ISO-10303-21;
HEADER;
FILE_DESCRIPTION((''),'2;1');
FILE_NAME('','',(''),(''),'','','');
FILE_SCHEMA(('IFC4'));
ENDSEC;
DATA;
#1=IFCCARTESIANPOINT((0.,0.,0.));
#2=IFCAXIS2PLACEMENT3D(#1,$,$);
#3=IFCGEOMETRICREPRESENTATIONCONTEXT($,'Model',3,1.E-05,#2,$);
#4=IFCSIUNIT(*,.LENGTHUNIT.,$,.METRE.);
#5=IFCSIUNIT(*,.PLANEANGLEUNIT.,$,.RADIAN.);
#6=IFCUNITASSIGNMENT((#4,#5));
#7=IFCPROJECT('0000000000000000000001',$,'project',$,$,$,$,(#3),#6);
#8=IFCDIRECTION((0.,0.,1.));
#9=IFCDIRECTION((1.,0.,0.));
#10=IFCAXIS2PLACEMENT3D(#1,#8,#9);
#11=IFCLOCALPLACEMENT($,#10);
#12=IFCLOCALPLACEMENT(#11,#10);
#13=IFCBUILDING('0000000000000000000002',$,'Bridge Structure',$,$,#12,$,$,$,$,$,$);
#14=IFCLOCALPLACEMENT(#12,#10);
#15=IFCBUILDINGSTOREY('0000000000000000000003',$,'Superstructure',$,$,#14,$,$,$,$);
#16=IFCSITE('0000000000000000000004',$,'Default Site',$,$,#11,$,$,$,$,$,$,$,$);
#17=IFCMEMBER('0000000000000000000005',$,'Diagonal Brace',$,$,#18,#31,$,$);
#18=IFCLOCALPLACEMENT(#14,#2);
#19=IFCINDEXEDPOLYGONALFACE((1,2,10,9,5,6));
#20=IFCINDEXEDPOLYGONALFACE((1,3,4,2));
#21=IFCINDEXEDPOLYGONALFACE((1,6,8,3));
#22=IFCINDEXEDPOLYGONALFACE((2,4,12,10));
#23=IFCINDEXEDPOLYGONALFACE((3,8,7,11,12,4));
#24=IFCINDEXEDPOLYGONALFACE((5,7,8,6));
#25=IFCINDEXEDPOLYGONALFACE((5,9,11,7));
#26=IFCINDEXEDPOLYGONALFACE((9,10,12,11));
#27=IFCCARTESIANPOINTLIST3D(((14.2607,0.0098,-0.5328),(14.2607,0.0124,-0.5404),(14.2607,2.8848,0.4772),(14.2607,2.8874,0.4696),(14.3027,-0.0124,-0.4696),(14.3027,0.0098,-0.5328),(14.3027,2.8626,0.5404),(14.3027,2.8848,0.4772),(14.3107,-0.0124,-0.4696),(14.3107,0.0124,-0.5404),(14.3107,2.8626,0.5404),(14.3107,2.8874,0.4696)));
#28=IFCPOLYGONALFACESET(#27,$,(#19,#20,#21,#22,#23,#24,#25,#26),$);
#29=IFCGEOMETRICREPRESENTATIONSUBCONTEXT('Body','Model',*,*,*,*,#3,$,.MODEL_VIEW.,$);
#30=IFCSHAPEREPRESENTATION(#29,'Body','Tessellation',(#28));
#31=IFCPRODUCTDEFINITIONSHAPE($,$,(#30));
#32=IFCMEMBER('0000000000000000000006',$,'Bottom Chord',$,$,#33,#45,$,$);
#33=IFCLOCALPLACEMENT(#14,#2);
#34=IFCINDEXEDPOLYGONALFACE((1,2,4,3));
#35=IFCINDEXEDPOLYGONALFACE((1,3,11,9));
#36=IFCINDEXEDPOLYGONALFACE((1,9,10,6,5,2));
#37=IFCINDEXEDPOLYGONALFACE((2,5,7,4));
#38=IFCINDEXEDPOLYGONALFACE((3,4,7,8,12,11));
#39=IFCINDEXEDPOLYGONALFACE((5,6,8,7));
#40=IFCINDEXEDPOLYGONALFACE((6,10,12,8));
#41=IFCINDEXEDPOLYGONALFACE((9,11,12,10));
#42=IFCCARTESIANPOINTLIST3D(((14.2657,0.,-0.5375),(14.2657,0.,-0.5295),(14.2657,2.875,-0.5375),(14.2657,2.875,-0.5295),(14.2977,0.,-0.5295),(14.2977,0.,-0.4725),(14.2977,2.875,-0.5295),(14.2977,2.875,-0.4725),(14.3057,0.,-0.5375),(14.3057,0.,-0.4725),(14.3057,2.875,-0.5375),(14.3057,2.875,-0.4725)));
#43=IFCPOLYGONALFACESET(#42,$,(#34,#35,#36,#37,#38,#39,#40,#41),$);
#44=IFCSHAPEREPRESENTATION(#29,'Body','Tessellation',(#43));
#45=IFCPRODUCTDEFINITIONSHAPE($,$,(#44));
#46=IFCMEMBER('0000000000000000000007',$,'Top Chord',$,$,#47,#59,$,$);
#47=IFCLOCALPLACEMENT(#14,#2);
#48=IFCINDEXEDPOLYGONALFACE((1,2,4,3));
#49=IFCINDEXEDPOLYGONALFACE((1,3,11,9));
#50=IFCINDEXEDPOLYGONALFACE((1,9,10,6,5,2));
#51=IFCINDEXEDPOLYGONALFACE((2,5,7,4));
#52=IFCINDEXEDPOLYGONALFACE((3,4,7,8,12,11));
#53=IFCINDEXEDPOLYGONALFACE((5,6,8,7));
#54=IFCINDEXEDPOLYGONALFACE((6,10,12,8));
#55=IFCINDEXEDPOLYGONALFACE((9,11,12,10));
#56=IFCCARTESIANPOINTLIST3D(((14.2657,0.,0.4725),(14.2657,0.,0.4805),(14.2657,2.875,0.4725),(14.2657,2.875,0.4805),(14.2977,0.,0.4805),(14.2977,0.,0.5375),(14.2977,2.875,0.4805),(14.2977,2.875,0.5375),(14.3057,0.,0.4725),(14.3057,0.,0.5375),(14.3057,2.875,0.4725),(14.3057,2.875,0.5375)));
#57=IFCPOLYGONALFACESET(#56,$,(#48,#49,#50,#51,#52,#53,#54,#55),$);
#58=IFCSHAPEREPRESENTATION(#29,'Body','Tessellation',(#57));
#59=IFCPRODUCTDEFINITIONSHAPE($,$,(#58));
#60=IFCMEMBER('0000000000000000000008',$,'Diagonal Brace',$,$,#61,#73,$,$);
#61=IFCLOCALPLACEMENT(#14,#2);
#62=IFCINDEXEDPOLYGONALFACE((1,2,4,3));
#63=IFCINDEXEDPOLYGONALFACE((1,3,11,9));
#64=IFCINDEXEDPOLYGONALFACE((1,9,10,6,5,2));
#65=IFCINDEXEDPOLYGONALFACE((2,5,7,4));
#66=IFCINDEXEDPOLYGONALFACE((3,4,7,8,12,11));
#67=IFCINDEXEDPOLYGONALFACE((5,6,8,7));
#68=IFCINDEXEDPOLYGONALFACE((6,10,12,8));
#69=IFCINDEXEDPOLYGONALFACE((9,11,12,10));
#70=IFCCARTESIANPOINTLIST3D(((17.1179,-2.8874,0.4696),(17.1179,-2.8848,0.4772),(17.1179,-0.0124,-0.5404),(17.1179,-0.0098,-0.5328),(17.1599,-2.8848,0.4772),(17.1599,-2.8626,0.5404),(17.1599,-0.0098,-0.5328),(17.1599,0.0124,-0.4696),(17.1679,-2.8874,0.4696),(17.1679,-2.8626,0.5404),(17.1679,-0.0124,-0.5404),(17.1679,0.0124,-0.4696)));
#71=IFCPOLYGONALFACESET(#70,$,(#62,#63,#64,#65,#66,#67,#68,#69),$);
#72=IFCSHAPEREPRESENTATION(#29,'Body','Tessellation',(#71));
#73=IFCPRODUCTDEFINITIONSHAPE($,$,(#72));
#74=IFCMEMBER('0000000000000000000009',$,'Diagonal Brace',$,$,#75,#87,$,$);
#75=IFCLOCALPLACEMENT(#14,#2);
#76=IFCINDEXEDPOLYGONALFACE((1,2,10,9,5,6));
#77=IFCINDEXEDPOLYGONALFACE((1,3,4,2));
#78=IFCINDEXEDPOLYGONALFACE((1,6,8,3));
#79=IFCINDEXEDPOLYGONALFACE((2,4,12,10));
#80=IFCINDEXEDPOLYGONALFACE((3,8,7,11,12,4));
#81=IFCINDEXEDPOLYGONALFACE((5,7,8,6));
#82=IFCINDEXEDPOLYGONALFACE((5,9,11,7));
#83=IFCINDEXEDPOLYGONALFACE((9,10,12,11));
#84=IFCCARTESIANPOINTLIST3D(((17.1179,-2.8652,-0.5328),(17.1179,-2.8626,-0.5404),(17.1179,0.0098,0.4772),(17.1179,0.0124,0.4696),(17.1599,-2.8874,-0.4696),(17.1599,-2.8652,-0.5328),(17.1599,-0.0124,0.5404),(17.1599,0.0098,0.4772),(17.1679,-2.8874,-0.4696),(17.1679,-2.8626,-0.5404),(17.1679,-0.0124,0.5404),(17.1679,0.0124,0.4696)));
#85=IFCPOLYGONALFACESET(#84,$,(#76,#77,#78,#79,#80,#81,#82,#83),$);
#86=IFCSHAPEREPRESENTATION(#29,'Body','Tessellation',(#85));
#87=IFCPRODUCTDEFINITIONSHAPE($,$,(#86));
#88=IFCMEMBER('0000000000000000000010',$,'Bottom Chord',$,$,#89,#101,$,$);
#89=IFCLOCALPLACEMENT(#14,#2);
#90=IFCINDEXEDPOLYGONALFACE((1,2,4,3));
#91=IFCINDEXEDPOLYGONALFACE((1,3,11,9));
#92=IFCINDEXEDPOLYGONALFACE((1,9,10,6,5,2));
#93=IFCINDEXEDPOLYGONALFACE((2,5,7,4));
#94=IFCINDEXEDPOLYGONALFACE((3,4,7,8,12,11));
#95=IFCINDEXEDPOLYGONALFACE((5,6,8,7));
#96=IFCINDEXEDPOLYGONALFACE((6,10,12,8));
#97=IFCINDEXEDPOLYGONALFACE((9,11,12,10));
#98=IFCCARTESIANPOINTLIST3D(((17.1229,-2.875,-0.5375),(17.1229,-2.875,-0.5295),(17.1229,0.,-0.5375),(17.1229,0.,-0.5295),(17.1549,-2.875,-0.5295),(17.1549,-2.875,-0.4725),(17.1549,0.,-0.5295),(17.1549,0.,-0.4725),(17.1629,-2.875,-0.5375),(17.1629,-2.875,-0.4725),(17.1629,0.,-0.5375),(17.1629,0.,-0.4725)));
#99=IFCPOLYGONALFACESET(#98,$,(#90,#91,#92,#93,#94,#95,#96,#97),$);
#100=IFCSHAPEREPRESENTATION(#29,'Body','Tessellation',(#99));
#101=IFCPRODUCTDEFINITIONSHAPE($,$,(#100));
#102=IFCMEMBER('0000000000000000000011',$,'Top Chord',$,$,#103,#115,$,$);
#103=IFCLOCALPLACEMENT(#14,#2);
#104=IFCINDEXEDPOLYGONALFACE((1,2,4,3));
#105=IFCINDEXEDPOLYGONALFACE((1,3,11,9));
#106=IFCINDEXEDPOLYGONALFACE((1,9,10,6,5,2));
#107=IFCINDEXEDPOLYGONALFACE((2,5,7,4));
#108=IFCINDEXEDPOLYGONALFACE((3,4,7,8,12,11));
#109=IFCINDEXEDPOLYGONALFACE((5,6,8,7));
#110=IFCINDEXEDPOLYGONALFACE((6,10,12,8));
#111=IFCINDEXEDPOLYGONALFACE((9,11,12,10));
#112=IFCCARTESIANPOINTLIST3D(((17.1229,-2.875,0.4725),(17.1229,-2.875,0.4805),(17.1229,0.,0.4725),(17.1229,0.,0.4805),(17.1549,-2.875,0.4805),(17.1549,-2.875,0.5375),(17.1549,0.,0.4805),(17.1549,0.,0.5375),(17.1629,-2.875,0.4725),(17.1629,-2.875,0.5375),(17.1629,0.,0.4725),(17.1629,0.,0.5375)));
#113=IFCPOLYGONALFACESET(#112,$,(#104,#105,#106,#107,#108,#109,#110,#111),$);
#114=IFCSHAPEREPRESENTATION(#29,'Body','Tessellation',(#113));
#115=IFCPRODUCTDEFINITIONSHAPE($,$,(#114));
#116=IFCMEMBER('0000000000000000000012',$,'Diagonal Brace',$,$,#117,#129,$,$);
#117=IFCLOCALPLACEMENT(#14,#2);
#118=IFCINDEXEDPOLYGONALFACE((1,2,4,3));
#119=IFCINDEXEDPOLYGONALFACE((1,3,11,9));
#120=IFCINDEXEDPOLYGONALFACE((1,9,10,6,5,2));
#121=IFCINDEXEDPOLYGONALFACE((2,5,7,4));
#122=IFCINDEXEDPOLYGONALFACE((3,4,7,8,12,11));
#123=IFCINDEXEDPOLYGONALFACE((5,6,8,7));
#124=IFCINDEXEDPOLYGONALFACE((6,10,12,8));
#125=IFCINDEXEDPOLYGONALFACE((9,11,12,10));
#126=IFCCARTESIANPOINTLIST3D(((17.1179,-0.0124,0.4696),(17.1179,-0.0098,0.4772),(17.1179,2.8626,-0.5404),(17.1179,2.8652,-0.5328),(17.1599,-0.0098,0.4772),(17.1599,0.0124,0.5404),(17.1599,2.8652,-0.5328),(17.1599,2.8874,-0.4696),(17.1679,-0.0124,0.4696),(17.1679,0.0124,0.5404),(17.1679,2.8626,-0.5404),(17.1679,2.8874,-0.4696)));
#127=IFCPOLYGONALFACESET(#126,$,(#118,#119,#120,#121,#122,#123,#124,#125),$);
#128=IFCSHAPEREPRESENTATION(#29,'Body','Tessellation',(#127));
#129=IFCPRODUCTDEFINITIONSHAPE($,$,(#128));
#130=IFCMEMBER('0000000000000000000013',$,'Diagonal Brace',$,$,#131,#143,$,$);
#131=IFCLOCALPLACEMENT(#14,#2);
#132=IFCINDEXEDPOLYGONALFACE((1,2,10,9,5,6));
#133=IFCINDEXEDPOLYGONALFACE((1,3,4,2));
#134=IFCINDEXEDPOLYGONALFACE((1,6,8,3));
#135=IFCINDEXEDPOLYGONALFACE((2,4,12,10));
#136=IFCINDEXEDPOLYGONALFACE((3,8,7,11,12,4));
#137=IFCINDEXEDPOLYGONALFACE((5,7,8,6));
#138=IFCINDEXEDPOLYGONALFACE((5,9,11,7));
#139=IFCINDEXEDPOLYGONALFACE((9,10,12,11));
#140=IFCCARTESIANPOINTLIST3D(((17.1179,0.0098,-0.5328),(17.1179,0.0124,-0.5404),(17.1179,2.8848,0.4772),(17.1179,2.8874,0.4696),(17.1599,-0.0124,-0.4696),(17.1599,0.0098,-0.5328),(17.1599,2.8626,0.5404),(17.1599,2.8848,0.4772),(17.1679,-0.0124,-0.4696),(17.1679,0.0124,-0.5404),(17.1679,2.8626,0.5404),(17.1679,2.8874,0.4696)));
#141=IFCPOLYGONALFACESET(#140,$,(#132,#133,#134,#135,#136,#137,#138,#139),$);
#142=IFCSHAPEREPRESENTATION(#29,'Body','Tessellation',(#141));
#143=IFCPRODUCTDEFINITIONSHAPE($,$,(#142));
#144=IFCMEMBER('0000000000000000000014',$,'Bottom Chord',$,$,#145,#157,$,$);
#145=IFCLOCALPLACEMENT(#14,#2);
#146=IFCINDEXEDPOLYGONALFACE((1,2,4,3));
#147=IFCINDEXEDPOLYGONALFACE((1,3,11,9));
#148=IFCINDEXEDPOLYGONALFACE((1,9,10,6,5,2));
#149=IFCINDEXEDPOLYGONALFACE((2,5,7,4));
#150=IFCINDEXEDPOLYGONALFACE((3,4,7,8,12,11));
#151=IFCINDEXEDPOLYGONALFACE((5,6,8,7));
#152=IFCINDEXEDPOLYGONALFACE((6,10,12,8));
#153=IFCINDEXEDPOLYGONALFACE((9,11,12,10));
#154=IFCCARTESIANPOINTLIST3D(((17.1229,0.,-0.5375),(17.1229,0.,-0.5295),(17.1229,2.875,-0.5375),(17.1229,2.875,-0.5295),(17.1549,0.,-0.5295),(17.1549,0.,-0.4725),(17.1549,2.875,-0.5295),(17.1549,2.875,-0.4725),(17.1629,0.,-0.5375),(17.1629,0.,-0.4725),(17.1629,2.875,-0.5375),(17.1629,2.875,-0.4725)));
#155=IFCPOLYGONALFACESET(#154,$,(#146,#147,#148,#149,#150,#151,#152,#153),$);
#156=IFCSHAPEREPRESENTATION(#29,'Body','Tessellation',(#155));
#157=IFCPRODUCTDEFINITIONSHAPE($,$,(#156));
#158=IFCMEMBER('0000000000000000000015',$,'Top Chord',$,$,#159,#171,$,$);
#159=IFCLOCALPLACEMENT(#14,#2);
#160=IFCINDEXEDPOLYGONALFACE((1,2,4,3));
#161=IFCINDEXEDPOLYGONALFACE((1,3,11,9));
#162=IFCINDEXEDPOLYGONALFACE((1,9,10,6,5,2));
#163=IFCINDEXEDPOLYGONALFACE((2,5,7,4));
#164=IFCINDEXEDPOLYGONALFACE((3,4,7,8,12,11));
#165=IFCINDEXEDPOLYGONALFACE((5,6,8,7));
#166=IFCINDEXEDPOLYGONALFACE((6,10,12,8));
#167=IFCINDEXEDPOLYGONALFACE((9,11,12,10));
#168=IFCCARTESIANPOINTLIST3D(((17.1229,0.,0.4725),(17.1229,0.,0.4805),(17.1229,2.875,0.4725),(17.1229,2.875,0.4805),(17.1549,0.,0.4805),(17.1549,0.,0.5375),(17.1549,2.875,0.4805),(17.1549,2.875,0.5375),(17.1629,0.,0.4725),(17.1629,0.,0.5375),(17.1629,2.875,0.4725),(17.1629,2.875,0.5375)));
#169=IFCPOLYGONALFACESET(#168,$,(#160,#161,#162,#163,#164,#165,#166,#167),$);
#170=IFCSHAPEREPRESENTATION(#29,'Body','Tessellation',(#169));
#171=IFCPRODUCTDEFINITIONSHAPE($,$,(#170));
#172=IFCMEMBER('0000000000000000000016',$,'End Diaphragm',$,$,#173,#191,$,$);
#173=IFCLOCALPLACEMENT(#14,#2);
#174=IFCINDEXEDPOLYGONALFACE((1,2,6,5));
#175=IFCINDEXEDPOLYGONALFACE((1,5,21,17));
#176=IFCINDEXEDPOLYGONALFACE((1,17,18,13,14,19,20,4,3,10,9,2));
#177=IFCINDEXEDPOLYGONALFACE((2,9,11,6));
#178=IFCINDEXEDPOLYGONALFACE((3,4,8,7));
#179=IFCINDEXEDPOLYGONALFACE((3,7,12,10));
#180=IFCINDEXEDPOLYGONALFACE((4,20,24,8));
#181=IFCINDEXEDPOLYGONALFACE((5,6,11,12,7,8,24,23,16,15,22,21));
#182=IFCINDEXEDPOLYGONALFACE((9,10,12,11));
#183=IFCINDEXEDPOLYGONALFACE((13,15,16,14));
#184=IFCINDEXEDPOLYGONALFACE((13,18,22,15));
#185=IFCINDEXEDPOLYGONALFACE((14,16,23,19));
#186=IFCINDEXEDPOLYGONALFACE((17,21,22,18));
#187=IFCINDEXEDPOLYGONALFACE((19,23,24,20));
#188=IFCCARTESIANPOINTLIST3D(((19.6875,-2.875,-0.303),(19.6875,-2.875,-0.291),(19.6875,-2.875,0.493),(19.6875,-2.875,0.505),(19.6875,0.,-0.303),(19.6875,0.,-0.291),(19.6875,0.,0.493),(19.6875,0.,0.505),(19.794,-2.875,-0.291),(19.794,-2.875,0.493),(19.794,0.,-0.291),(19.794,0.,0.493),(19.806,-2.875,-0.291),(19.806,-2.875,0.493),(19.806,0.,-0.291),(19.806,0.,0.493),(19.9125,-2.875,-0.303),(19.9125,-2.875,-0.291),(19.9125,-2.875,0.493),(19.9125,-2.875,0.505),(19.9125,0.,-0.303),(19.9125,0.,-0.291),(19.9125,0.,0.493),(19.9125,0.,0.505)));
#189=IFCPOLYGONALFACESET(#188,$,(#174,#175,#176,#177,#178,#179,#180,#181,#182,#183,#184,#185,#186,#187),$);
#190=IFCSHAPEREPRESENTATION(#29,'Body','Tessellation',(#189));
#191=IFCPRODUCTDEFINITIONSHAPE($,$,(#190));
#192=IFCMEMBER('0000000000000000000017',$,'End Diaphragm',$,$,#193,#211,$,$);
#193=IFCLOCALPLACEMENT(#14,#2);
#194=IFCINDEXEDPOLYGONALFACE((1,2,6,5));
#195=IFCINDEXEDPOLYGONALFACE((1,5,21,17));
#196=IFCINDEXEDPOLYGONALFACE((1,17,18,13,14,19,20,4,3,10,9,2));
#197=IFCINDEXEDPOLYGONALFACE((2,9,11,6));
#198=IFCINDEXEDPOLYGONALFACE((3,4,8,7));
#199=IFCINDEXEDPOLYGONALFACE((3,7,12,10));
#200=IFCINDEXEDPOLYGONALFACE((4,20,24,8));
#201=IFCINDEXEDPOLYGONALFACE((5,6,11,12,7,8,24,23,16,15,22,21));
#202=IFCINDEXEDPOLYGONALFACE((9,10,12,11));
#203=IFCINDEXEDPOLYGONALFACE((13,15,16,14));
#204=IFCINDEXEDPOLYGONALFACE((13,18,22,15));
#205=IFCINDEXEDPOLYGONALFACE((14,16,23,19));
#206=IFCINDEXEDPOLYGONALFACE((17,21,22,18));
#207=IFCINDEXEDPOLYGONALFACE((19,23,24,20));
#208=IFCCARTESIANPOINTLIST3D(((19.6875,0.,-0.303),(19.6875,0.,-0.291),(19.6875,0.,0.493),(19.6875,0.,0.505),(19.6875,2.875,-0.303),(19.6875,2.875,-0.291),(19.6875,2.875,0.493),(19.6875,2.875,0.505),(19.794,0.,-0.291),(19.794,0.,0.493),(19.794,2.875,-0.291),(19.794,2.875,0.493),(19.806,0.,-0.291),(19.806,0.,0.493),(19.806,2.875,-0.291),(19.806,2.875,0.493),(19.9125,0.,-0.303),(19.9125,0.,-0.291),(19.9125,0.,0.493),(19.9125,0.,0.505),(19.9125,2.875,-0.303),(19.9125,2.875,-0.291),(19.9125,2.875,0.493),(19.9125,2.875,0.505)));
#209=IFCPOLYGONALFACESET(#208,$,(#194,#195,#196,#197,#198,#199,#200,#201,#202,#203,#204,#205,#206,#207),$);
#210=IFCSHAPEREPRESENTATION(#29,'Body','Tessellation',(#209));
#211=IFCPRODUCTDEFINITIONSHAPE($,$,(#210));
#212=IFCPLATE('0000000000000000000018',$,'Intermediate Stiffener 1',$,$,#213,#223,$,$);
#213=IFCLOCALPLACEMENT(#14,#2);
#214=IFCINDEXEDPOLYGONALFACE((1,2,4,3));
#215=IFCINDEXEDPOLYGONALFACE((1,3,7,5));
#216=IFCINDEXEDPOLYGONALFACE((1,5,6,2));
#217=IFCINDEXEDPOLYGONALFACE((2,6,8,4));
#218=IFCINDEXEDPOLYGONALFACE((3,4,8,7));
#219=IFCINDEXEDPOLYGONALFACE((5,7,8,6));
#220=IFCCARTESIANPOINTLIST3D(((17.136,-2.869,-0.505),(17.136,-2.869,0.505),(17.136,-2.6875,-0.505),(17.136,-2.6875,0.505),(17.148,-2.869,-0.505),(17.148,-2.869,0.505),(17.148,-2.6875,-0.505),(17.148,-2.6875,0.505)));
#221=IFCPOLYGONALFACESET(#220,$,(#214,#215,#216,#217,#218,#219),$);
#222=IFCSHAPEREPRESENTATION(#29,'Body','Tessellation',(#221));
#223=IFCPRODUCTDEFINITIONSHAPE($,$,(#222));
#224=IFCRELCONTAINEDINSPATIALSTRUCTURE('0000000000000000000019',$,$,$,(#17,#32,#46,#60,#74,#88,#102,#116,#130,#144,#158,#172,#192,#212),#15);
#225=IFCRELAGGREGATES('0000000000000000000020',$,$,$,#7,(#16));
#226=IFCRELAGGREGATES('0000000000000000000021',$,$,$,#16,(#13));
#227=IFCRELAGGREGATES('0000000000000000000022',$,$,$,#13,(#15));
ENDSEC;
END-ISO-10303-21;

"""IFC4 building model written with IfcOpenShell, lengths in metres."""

from ifc_helpers import new_model, si_unit, frame, origin, origin_with_axes, origin_2d_with_axis, place, context, subcontext, project, spatial, rectangle, i_section, l_section, extrude, element, save


model = new_model("IFC4")

# Units and contexts
model_context = context("Model", 3, precision=1e-05, world=origin())
body_context = subcontext(model_context, "Body", "Model", "MODEL_VIEW")
ifc_project = project(units=[si_unit("LENGTHUNIT", "METRE"), si_unit("PLANEANGLEUNIT", "RADIAN")], contexts=[model_context])

# Site, building, storey
site_placement = place(None, origin_with_axes())
site = spatial("IfcSite", under=ifc_project, at=site_placement, Name="Default Site")
building_placement = place(site_placement, origin_with_axes())
building = spatial("IfcBuilding", under=site, at=building_placement, Name="Bridge Structure")
storey_placement = place(building_placement, origin_with_axes())
storey = spatial("IfcBuildingStorey", under=building, at=storey_placement, Name="Superstructure")

# Members
member_placement = place(storey_placement, frame((14.2857, 0.0, -0.505), z_axis=(0.0, 0.943474, 0.331447), x_axis=(-1.0, 0.0, 0.0)))
element("IfcMember", 1, at=member_placement, inside=storey, Name="Diagonal Brace", context=body_context, shape_type="SweptSolid", body=[
    extrude(l_section(Depth=0.075, Width=0.05, Thickness=0.008, at=origin_2d_with_axis()), origin_with_axes(), (0.0, 0.0, 1.0), 3.0472),
])
for number, where, z_axis, x_axis, name in (
    (2, (14.2857, 0.0, -0.505), (0.0, 1.0, 0.0), (-1.0, 0.0, 0.0), "Bottom Chord"),
    (3, (14.2857, 0.0, 0.505), (0.0, 1.0, 0.0), (-1.0, 0.0, 0.0), "Top Chord"),
):
    element("IfcMember", number, at=place(storey_placement, frame(where, z_axis=z_axis, x_axis=x_axis)), inside=storey, Name=name, context=body_context, shape_type="SweptSolid", body=[
        extrude(l_section(Depth=0.065, Width=0.04, Thickness=0.008, at=origin_2d_with_axis()), origin_with_axes(), (0.0, 0.0, 1.0), 2.875),
    ])
for number, where, z_axis, x_axis, name in (
    (4, (17.1429, -2.875, 0.505), (0.0, 0.943474, -0.331447), (-1.0, 0.0, 0.0), "Diagonal Brace"),
    (5, (17.1429, -2.875, -0.505), (0.0, 0.943474, 0.331447), (-1.0, 0.0, 0.0), "Diagonal Brace"),
):
    element("IfcMember", number, at=place(storey_placement, frame(where, z_axis=z_axis, x_axis=x_axis)), inside=storey, Name=name, context=body_context, shape_type="SweptSolid", body=[
        extrude(l_section(Depth=0.075, Width=0.05, Thickness=0.008, at=origin_2d_with_axis()), origin_with_axes(), (0.0, 0.0, 1.0), 3.0472),
    ])
for number, where, z_axis, x_axis, name in (
    (6, (17.1429, -2.875, -0.505), (0.0, 1.0, 0.0), (-1.0, 0.0, 0.0), "Bottom Chord"),
    (7, (17.1429, -2.875, 0.505), (0.0, 1.0, 0.0), (-1.0, 0.0, 0.0), "Top Chord"),
):
    element("IfcMember", number, at=place(storey_placement, frame(where, z_axis=z_axis, x_axis=x_axis)), inside=storey, Name=name, context=body_context, shape_type="SweptSolid", body=[
        extrude(l_section(Depth=0.065, Width=0.04, Thickness=0.008, at=origin_2d_with_axis()), origin_with_axes(), (0.0, 0.0, 1.0), 2.875),
    ])
for number, where, z_axis, x_axis, name in (
    (8, (17.1429, 0.0, 0.505), (0.0, 0.943474, -0.331447), (-1.0, 0.0, 0.0), "Diagonal Brace"),
    (9, (17.1429, 0.0, -0.505), (0.0, 0.943474, 0.331447), (-1.0, 0.0, 0.0), "Diagonal Brace"),
):
    element("IfcMember", number, at=place(storey_placement, frame(where, z_axis=z_axis, x_axis=x_axis)), inside=storey, Name=name, context=body_context, shape_type="SweptSolid", body=[
        extrude(l_section(Depth=0.075, Width=0.05, Thickness=0.008, at=origin_2d_with_axis()), origin_with_axes(), (0.0, 0.0, 1.0), 3.0472),
    ])
for number, where, z_axis, x_axis, name in (
    (10, (17.1429, 0.0, -0.505), (0.0, 1.0, 0.0), (-1.0, 0.0, 0.0), "Bottom Chord"),
    (11, (17.1429, 0.0, 0.505), (0.0, 1.0, 0.0), (-1.0, 0.0, 0.0), "Top Chord"),
):
    element("IfcMember", number, at=place(storey_placement, frame(where, z_axis=z_axis, x_axis=x_axis)), inside=storey, Name=name, context=body_context, shape_type="SweptSolid", body=[
        extrude(l_section(Depth=0.065, Width=0.04, Thickness=0.008, at=origin_2d_with_axis()), origin_with_axes(), (0.0, 0.0, 1.0), 2.875),
    ])
for number, where, z_axis, x_axis, name in (
    (12, (19.8, -2.875, 0.101), (0.0, 1.0, 0.0), (-1.0, 0.0, 0.0), "End Diaphragm"),
    (13, (19.8, 0.0, 0.101), (0.0, 1.0, 0.0), (-1.0, 0.0, 0.0), "End Diaphragm"),
):
    element("IfcMember", number, at=place(storey_placement, frame(where, z_axis=z_axis, x_axis=x_axis)), inside=storey, Name=name, context=body_context, shape_type="SweptSolid", body=[
        extrude(i_section(OverallWidth=0.225, OverallDepth=0.808, WebThickness=0.012, FlangeThickness=0.012, at=origin_2d_with_axis()), origin_with_axes(), (0.0, 0.0, 1.0), 2.875),
    ])

# Plate
for number, where, z_axis, x_axis, name in (
    (14, (17.142, -2.7782, -0.505), (0.0, 0.0, 1.0), (1.0, 0.0, 0.0), "Intermediate Stiffener 1"),
):
    element("IfcPlate", number, at=place(storey_placement, frame(where, z_axis=z_axis, x_axis=x_axis)), inside=storey, Name=name, context=body_context, shape_type="SweptSolid", body=[
        extrude(rectangle(XDim=0.012, YDim=0.1815, at=origin_2d_with_axis()), origin_with_axes(), (0.0, 0.0, 1.0), 1.01),
    ])

save(model, "model.ifc")
